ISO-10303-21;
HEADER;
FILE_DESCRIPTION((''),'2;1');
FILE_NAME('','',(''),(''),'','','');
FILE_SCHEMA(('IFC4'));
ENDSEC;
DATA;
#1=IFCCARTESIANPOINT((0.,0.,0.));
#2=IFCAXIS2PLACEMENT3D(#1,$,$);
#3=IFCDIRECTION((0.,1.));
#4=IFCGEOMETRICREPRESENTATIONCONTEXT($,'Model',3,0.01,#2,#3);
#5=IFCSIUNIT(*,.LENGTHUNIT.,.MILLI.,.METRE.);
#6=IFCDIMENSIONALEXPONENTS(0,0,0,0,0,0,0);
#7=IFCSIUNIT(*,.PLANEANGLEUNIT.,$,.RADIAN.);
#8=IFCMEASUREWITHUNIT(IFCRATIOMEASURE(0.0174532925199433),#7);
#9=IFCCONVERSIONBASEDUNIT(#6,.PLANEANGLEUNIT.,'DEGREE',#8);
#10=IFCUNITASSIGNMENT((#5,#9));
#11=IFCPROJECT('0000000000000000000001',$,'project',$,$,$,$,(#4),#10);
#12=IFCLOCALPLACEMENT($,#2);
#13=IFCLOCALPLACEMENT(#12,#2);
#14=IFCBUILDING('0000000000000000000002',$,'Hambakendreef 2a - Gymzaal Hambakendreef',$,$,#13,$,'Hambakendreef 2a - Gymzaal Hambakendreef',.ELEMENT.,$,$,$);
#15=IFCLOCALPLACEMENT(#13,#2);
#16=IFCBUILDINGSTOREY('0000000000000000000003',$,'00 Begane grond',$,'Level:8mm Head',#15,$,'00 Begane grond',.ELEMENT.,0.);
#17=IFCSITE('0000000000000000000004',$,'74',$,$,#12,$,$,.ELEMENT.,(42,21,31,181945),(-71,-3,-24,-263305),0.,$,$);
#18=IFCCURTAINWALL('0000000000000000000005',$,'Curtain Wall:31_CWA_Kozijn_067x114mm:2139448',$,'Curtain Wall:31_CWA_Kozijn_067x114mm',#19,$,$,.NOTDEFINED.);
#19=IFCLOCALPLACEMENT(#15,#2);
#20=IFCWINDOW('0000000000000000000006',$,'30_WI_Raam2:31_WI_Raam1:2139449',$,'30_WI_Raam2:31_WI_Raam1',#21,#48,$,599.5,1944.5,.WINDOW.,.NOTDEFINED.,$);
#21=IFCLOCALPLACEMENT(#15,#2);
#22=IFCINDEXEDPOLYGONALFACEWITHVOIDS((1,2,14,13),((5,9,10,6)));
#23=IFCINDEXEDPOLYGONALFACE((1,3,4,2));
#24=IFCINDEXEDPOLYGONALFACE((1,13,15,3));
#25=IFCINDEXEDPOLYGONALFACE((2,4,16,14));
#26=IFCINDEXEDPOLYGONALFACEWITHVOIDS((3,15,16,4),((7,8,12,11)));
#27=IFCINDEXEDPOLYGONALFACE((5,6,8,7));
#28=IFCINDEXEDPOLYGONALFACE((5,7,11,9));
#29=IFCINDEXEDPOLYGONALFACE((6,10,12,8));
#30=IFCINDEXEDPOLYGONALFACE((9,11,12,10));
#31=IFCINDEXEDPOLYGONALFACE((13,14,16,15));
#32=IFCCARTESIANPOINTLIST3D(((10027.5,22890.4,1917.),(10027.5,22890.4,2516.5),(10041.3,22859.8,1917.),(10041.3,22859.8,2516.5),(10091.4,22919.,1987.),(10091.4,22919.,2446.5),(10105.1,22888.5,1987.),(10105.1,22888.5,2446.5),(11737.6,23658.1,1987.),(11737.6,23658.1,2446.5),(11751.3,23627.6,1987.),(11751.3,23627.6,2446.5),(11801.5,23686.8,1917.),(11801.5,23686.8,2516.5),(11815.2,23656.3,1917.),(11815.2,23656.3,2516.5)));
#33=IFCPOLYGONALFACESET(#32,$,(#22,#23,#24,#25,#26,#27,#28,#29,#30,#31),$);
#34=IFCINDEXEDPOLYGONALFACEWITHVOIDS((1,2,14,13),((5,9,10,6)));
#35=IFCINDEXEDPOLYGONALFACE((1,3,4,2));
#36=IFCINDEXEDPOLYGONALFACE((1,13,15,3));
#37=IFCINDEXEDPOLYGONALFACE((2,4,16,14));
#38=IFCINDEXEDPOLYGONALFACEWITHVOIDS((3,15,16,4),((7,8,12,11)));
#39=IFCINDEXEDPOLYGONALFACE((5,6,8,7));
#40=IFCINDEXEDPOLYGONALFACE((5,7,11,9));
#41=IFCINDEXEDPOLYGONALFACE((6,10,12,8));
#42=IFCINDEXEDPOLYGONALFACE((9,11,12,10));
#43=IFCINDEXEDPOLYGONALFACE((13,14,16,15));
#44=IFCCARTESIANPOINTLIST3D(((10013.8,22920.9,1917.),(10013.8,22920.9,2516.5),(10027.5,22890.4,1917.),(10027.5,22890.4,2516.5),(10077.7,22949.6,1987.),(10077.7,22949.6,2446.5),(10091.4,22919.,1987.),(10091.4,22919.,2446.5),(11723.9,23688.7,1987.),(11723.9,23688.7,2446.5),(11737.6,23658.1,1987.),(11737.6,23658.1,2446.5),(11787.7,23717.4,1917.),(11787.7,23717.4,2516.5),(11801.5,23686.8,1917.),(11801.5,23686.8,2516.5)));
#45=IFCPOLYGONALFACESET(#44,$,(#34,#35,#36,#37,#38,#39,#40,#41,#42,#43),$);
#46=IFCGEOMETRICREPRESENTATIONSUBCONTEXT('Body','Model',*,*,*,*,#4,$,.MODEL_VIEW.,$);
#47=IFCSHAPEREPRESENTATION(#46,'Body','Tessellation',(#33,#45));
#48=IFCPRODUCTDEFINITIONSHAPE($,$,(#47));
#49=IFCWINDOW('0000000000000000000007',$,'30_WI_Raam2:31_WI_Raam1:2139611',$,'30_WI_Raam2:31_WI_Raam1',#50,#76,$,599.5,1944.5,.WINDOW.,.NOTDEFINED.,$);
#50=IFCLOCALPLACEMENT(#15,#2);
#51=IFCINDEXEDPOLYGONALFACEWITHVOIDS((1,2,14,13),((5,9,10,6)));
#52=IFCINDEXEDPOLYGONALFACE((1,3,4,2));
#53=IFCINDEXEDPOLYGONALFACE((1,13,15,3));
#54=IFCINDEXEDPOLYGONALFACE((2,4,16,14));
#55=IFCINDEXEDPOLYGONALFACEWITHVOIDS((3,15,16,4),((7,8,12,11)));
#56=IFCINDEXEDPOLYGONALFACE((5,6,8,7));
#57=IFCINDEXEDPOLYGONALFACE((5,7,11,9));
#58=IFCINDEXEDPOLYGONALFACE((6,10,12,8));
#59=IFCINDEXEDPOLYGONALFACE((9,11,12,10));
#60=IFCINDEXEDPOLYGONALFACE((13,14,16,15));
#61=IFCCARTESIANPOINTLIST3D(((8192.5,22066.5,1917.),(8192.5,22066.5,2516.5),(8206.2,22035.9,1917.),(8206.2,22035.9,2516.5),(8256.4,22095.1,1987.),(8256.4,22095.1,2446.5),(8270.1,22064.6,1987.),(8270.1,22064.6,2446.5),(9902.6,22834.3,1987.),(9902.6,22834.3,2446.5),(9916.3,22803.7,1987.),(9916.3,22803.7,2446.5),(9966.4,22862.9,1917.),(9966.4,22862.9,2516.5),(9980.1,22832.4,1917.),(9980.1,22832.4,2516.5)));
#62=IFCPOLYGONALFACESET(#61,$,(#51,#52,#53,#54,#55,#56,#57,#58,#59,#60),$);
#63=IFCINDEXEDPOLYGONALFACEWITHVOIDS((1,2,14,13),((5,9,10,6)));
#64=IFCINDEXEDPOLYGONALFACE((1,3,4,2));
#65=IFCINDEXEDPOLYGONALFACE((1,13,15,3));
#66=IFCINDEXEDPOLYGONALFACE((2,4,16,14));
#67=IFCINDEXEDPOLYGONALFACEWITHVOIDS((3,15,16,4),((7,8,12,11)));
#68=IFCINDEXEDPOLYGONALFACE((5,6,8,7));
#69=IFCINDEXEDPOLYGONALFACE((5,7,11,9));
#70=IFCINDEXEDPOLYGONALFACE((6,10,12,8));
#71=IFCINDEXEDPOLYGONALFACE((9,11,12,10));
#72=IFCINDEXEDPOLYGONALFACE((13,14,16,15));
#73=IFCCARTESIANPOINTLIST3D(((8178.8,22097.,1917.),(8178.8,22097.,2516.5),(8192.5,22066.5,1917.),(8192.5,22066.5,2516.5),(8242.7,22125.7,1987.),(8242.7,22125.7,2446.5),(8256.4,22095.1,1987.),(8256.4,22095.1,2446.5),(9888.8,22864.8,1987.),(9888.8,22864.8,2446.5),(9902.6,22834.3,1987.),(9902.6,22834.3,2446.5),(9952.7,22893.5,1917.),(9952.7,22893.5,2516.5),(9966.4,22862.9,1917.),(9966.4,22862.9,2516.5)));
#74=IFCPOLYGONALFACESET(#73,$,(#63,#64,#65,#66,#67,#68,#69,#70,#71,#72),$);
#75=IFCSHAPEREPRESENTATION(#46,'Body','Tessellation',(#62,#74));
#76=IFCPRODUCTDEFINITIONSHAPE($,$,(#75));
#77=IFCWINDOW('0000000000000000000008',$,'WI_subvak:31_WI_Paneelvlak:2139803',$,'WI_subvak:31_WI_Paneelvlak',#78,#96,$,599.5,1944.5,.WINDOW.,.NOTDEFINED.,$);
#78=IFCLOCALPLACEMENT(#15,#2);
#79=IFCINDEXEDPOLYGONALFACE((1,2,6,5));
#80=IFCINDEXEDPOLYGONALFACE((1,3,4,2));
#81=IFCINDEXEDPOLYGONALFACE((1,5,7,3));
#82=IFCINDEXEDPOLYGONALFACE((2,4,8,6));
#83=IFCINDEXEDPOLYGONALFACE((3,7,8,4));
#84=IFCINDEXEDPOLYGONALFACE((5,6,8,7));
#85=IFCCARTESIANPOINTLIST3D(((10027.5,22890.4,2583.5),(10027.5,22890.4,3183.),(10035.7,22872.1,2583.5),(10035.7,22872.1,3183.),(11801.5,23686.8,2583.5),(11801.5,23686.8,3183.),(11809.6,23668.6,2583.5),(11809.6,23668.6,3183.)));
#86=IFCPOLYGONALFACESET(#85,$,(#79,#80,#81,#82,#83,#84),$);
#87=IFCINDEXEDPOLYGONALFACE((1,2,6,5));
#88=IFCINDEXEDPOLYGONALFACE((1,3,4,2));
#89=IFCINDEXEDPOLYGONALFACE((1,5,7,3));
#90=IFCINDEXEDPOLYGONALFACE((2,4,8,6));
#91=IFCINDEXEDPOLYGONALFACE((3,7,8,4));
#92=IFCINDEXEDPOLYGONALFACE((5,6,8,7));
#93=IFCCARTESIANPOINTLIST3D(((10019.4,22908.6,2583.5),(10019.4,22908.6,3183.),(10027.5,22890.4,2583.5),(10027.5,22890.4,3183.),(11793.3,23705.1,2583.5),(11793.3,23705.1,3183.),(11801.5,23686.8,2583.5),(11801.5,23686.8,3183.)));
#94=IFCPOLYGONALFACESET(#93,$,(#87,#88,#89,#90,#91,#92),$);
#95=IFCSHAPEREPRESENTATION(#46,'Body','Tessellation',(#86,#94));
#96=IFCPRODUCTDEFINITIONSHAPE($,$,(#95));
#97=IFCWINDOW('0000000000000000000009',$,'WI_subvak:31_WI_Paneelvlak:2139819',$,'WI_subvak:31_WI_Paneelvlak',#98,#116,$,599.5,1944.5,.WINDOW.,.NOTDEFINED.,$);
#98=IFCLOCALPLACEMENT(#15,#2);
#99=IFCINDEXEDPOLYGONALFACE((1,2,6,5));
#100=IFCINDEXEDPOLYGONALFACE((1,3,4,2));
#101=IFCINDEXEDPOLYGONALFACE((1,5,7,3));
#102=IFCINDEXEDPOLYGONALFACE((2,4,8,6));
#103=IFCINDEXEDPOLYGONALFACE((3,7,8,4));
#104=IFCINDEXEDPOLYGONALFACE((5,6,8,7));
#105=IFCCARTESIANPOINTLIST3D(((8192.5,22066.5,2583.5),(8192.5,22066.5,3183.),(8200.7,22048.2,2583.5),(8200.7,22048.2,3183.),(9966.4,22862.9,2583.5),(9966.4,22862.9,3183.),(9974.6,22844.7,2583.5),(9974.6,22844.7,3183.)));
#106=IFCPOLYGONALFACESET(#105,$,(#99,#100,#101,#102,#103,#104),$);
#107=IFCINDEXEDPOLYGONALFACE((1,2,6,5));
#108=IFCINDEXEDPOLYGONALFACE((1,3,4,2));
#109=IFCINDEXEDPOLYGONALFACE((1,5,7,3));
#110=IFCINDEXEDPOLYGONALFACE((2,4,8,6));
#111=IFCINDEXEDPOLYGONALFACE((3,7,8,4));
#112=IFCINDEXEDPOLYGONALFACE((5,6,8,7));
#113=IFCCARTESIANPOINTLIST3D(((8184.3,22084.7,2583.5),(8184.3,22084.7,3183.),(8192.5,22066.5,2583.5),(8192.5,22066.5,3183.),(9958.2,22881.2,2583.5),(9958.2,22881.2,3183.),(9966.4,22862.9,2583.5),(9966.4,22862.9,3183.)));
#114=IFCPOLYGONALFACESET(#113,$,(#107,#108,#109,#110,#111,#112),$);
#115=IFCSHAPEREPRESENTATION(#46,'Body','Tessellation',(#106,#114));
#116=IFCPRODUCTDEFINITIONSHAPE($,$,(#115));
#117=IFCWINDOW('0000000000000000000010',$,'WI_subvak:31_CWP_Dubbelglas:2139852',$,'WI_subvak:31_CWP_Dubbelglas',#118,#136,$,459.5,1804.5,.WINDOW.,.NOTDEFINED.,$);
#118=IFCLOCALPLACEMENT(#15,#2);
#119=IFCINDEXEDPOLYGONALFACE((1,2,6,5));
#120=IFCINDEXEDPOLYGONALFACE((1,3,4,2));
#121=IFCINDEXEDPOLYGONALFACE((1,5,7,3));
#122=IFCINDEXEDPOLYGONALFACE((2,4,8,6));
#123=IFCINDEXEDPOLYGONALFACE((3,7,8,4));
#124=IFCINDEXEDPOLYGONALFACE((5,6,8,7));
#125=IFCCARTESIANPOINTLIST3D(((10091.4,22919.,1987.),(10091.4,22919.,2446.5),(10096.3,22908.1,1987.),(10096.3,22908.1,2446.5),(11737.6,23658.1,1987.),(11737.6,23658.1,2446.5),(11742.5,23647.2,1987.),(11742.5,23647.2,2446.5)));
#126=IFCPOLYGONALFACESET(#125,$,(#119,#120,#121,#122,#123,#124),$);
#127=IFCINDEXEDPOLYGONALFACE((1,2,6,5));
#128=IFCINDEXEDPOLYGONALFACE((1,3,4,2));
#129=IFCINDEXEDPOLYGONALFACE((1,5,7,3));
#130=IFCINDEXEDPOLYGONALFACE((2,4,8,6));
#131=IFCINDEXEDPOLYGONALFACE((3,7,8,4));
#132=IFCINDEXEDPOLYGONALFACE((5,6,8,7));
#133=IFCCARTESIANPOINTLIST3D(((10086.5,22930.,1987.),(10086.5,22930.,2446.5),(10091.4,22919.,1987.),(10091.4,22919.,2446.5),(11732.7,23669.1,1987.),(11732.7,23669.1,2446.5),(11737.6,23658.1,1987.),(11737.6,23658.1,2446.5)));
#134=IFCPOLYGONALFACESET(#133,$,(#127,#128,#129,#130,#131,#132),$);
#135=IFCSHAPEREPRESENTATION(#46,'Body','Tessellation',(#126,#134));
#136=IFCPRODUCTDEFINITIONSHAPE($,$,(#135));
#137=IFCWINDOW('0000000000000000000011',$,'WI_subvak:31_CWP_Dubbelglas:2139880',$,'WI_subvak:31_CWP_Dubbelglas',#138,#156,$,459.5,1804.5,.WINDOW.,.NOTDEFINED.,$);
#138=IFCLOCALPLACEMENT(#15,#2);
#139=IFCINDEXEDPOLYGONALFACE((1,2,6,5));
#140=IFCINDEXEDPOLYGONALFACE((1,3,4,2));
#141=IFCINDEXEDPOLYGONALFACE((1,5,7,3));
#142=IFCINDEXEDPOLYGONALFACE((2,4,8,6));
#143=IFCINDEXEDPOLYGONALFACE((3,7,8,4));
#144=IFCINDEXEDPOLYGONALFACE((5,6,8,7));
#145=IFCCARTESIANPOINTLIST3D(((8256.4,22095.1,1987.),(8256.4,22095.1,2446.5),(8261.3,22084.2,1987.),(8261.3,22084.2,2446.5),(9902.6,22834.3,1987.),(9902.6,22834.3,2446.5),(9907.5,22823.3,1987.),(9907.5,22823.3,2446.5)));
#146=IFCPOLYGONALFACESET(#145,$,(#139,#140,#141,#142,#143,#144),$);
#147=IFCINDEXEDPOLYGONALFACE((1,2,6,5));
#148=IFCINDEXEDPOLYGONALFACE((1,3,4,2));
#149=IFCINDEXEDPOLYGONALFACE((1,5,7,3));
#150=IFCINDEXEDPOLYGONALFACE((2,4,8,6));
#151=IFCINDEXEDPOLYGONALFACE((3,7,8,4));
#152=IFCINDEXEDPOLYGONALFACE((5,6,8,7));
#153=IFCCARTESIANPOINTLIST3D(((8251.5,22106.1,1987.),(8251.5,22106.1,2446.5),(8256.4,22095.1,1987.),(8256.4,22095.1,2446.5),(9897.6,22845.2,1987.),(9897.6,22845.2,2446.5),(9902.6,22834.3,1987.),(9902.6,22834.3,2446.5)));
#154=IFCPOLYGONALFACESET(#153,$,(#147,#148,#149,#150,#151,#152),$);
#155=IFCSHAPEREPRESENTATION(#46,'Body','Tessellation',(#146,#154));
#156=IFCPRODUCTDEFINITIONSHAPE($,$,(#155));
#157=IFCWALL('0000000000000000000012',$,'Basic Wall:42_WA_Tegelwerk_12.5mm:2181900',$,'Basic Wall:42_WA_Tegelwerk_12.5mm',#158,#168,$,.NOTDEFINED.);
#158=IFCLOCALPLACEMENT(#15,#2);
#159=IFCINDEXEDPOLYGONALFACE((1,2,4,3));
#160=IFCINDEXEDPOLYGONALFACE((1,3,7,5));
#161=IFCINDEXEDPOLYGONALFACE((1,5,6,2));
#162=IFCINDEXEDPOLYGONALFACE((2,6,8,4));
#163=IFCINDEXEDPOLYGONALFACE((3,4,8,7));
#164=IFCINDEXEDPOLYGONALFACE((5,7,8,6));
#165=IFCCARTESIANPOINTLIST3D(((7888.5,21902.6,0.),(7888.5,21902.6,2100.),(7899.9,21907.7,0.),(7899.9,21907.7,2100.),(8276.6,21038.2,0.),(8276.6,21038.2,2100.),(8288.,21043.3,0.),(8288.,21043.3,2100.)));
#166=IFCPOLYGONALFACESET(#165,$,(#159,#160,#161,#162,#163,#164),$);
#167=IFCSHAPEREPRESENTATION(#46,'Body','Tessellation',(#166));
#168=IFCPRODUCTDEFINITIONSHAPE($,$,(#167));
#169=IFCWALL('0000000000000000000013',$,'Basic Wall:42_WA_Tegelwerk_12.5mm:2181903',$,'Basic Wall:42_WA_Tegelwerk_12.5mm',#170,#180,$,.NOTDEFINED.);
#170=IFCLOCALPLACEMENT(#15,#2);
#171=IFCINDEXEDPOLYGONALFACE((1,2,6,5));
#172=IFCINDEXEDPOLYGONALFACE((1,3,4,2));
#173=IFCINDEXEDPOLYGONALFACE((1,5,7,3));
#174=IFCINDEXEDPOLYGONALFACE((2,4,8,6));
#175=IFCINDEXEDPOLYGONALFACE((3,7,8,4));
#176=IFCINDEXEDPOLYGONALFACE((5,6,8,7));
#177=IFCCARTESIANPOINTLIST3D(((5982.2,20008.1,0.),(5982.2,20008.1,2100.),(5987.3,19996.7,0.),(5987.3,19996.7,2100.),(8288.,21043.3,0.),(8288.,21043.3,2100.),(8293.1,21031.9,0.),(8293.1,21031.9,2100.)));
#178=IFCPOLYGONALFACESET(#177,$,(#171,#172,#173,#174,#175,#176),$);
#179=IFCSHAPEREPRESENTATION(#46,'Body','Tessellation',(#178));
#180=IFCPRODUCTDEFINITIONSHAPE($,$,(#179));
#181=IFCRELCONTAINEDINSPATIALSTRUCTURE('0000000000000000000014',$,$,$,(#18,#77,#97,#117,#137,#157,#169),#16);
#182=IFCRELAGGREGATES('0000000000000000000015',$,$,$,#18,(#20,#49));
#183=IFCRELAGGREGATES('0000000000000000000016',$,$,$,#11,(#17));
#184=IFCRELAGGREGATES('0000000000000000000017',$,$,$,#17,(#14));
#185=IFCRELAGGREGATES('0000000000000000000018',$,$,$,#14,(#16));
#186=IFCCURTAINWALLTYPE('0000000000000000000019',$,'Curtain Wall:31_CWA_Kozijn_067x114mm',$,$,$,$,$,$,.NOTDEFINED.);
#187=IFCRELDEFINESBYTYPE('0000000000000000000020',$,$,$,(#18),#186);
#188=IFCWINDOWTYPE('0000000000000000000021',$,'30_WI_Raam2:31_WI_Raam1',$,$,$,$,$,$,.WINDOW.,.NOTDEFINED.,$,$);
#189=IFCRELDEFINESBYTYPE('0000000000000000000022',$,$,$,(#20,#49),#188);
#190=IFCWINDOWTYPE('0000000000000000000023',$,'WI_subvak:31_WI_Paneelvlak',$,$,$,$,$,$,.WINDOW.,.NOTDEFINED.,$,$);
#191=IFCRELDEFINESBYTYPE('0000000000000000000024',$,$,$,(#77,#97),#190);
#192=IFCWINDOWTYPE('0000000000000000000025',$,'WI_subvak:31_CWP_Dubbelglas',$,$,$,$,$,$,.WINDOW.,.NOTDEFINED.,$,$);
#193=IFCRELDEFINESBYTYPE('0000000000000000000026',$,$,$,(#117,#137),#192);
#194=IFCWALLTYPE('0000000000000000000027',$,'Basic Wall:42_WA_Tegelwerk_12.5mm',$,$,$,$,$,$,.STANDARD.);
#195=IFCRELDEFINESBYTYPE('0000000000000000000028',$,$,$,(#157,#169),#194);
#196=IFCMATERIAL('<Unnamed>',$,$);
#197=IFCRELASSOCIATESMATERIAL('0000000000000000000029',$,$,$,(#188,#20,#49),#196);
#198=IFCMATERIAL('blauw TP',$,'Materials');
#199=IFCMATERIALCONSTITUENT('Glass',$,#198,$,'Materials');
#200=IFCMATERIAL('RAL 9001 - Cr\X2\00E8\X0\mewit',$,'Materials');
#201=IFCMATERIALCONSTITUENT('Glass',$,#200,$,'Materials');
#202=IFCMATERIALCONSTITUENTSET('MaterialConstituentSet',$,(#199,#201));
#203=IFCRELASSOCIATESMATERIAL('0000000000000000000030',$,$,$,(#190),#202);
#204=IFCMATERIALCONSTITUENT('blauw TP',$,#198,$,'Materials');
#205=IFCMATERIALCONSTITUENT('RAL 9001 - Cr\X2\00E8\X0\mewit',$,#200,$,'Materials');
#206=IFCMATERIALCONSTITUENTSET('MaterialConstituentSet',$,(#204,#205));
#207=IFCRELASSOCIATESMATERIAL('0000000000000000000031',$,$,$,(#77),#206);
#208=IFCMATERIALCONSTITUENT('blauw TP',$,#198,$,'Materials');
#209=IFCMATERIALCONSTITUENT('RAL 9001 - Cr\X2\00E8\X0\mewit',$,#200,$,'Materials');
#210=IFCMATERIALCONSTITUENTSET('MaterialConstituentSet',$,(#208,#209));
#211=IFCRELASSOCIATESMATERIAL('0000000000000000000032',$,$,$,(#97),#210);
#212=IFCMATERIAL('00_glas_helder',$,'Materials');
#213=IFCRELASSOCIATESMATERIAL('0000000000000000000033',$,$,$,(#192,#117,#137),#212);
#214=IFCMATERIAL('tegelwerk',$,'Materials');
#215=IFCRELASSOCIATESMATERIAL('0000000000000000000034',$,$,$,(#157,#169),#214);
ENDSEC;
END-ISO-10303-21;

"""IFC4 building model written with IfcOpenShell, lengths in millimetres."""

from ifc_helpers import new_model, entity, si_unit, converted_unit, direction, frame, origin, place, context, subcontext, project, spatial, indexed_curve, outline, extrude, source, transform, mapped, material, constituent, constituent_set, type_object, type_shapes, element, aggregate, save


model = new_model("IFC4")

# Units and contexts
model_context = context("Model", 3, precision=0.01, world=origin(), true_north=direction((0.0, 1.0)))
body_context = subcontext(model_context, "Body", "Model", "MODEL_VIEW")
ifc_project = project(units=[si_unit("LENGTHUNIT", "METRE", prefix="MILLI"), converted_unit("PLANEANGLEUNIT", "DEGREE", entity("IfcRatioMeasure", 0.0174532925199433), si_unit("PLANEANGLEUNIT", "RADIAN"), dimensions=[0, 0, 0, 0, 0, 0, 0])], contexts=[model_context])

# Site, building, storey
site_placement = place(None, origin())
site = spatial("IfcSite", under=ifc_project, at=site_placement, Name="74", CompositionType="ELEMENT", RefLatitude=(42, 21, 31, 181945), RefLongitude=(-71, -3, -24, -263305), RefElevation=0.0)
building_placement = place(site_placement, origin())
building = spatial("IfcBuilding", under=site, at=building_placement, Name="Hambakendreef 2a - Gymzaal Hambakendreef", LongName="Hambakendreef 2a - Gymzaal Hambakendreef", CompositionType="ELEMENT")
storey_placement = place(building_placement, origin())
storey = spatial("IfcBuildingStorey", under=building, at=storey_placement, Name="00 Begane grond", ObjectType="Level:8mm Head", LongName="00 Begane grond", CompositionType="ELEMENT", Elevation=0.0)

# Curtain wall
curtain_wall_type_1 = type_object("IfcCurtainWallType", Name="Curtain Wall:31_CWA_Kozijn_067x114mm", PredefinedType="NOTDEFINED")
curtain_wall_1_placement = place(storey_placement, origin())
curtain_wall_1 = element("IfcCurtainWall", 1, at=curtain_wall_1_placement, inside=storey, type_object=curtain_wall_type_1, Name="Curtain Wall:31_CWA_Kozijn_067x114mm:2139448", ObjectType="Curtain Wall:31_CWA_Kozijn_067x114mm", PredefinedType="NOTDEFINED")

# Shared definitions
ifc_material_1 = material(Name="<Unnamed>")

# Windows
window_type_1 = type_object("IfcWindowType", Name="30_WI_Raam2:31_WI_Raam1", PartitioningType="NOTDEFINED", PredefinedType="WINDOW", material=ifc_material_1)
shared_shape_1 = source(origin(), body_context, "Body", "SweptSolid", [
    extrude(outline(indexed_curve([(-972.2, -299.7), (972.2, -299.7), (972.2, 299.7), (-972.2, 299.7), (-972.2, -299.7)], self_intersect=False), holes=[indexed_curve([(-902.2, 229.7), (902.2, 229.7), (902.2, -229.8), (-902.2, -229.8), (-902.2, 229.7)], self_intersect=False)]), frame((0.0, 0.0, 299.8), z_axis=(0.0, 1.0, 0.0), x_axis=(1.0, 0.0, 0.0)), (0.0, 0.0, 1.0), 33.5),
    extrude(outline(indexed_curve([(-972.2, -299.7), (972.2, -299.7), (972.2, 299.7), (-972.2, 299.7), (-972.2, -299.7)], self_intersect=False), holes=[indexed_curve([(-902.2, 229.7), (902.2, 229.7), (902.2, -229.8), (-902.2, -229.8), (-902.2, 229.7)], self_intersect=False)]), frame((0.0, -33.5, 299.8), z_axis=(0.0, 1.0, 0.0), x_axis=(1.0, 0.0, 0.0)), (0.0, 0.0, 1.0), 33.5),
])
type_shapes(window_type_1, [shared_shape_1])
window_1_placement = place(curtain_wall_1_placement, frame((10914.5, 23288.6, 1917.0), z_axis=(0.0, 0.0, 1.0), x_axis=(-0.91227, -0.40959, 0.0)))
window_1 = element("IfcWindow", 2, at=window_1_placement, type_object=window_type_1, material=ifc_material_1, Name="30_WI_Raam2:31_WI_Raam1:2139449", ObjectType="30_WI_Raam2:31_WI_Raam1", OverallHeight=599.5, OverallWidth=1944.5, PartitioningType="NOTDEFINED", PredefinedType="WINDOW", context=body_context, shape_type="MappedRepresentation", body=[
    mapped(shared_shape_1, transform((0.0, 0.0, 0.0), scale=1.0)),
])
window_2_placement = place(curtain_wall_1_placement, frame((9079.5, 22464.7, 1917.0), z_axis=(0.0, 0.0, 1.0), x_axis=(-0.91227, -0.40959, 0.0)))
window_2 = element("IfcWindow", 3, at=window_2_placement, type_object=window_type_1, material=ifc_material_1, Name="30_WI_Raam2:31_WI_Raam1:2139611", ObjectType="30_WI_Raam2:31_WI_Raam1", OverallHeight=599.5, OverallWidth=1944.5, PartitioningType="NOTDEFINED", PredefinedType="WINDOW", context=body_context, shape_type="MappedRepresentation", body=[
    mapped(shared_shape_1, transform((0.0, 0.0, 0.0), scale=1.0)),
])
aggregate(curtain_wall_1, [window_1, window_2])

# Windows
ifc_material_2 = material(Name="blauw TP", Category="Materials")
ifc_constituent_1 = constituent(ifc_material_2, Name="blauw TP", Category="Materials")
ifc_material_3 = material(Name="RAL 9001 - Crèmewit", Category="Materials")
ifc_constituent_2 = constituent(ifc_material_3, Name="RAL 9001 - Crèmewit", Category="Materials")
ifc_constituent_set_1 = constituent_set(constituents=[ifc_constituent_1, ifc_constituent_2], Name="MaterialConstituentSet")
ifc_constituent_3 = constituent(ifc_material_2, Name="Glass", Category="Materials")
ifc_constituent_4 = constituent(ifc_material_3, Name="Glass", Category="Materials")
ifc_constituent_set_2 = constituent_set(constituents=[ifc_constituent_3, ifc_constituent_4], Name="MaterialConstituentSet")
window_type_2 = type_object("IfcWindowType", Name="WI_subvak:31_WI_Paneelvlak", PartitioningType="NOTDEFINED", PredefinedType="WINDOW", material=ifc_constituent_set_2)
shared_shape_2 = source(origin(), body_context, "Body", "SweptSolid", [
    extrude(outline(indexed_curve([(-10.0, -972.2), (10.0, -972.2), (10.0, 972.2), (-10.0, 972.2), (-10.0, -972.2)], self_intersect=False)), frame((0.0, 10.0, 0.0), z_axis=(0.0, 0.0, 1.0), x_axis=(0.0, -1.0, 0.0)), (0.0, 0.0, 1.0), 599.5),
    extrude(outline(indexed_curve([(-10.0, -972.2), (10.0, -972.2), (10.0, 972.2), (-10.0, 972.2), (-10.0, -972.2)], self_intersect=False)), frame((0.0, -10.0, 0.0), z_axis=(0.0, 0.0, 1.0), x_axis=(0.0, -1.0, 0.0)), (0.0, 0.0, 1.0), 599.5),
])
type_shapes(window_type_2, [shared_shape_2])
window_3_placement = place(storey_placement, frame((10914.5, 23288.6, 2583.5), z_axis=(0.0, 0.0, 1.0), x_axis=(-0.91227, -0.40959, 0.0)))
element("IfcWindow", 4, at=window_3_placement, inside=storey, type_object=window_type_2, material=ifc_constituent_set_1, Name="WI_subvak:31_WI_Paneelvlak:2139803", ObjectType="WI_subvak:31_WI_Paneelvlak", OverallHeight=599.5, OverallWidth=1944.5, PartitioningType="NOTDEFINED", PredefinedType="WINDOW", context=body_context, shape_type="MappedRepresentation", body=[
    mapped(shared_shape_2, transform((0.0, 0.0, 0.0), scale=1.0)),
])
ifc_constituent_5 = constituent(ifc_material_2, Name="blauw TP", Category="Materials")
ifc_constituent_6 = constituent(ifc_material_3, Name="RAL 9001 - Crèmewit", Category="Materials")
ifc_constituent_set_3 = constituent_set(constituents=[ifc_constituent_5, ifc_constituent_6], Name="MaterialConstituentSet")
window_4_placement = place(storey_placement, frame((9079.5, 22464.7, 2583.5), z_axis=(0.0, 0.0, 1.0), x_axis=(-0.91227, -0.40959, 0.0)))
element("IfcWindow", 5, at=window_4_placement, inside=storey, type_object=window_type_2, material=ifc_constituent_set_3, Name="WI_subvak:31_WI_Paneelvlak:2139819", ObjectType="WI_subvak:31_WI_Paneelvlak", OverallHeight=599.5, OverallWidth=1944.5, PartitioningType="NOTDEFINED", PredefinedType="WINDOW", context=body_context, shape_type="MappedRepresentation", body=[
    mapped(shared_shape_2, transform((0.0, 0.0, 0.0), scale=1.0)),
])
ifc_material_4 = material(Name="00_glas_helder", Category="Materials")
window_type_3 = type_object("IfcWindowType", Name="WI_subvak:31_CWP_Dubbelglas", PartitioningType="NOTDEFINED", PredefinedType="WINDOW", material=ifc_material_4)
shared_shape_3 = source(origin(), body_context, "Body", "SweptSolid", [
    extrude(outline(indexed_curve([(-6.0, -902.2), (6.0, -902.2), (6.0, 902.2), (-6.0, 902.2), (-6.0, -902.2)], self_intersect=False)), frame((0.0, 6.0, 0.0), z_axis=(0.0, 0.0, 1.0), x_axis=(0.0, -1.0, 0.0)), (0.0, 0.0, 1.0), 459.5),
    extrude(outline(indexed_curve([(-6.0, -902.2), (6.0, -902.2), (6.0, 902.2), (-6.0, 902.2), (-6.0, -902.2)], self_intersect=False)), frame((0.0, -6.0, 0.0), z_axis=(0.0, 0.0, 1.0), x_axis=(0.0, -1.0, 0.0)), (0.0, 0.0, 1.0), 459.5),
])
type_shapes(window_type_3, [shared_shape_3])
for number, where, z_axis, x_axis, name in (
    (6, (10914.5, 23288.6, 1987.0), (0.0, 0.0, 1.0), (-0.91227, -0.40959, 0.0), "WI_subvak:31_CWP_Dubbelglas:2139852"),
    (7, (9079.5, 22464.7, 1987.0), (0.0, 0.0, 1.0), (-0.91227, -0.40959, 0.0), "WI_subvak:31_CWP_Dubbelglas:2139880"),
):
    element("IfcWindow", number, at=place(storey_placement, frame(where, z_axis=z_axis, x_axis=x_axis)), inside=storey, type_object=window_type_3, material=ifc_material_4, Name=name, ObjectType="WI_subvak:31_CWP_Dubbelglas", OverallHeight=459.5, OverallWidth=1804.5, PartitioningType="NOTDEFINED", PredefinedType="WINDOW", context=body_context, shape_type="MappedRepresentation", body=[
        mapped(shared_shape_3, transform((0.0, 0.0, 0.0), scale=1.0)),
    ])

# Walls
ifc_material_5 = material(Name="tegelwerk", Category="Materials")
wall_type_1 = type_object("IfcWallType", Name="Basic Wall:42_WA_Tegelwerk_12.5mm", PredefinedType="STANDARD")
wall_1_placement = place(storey_placement, frame((7894.2, 21905.1, 0.0), z_axis=(0.0, 0.0, 1.0), x_axis=(0.40959, -0.91227, 0.0)))
element("IfcWall", 8, at=wall_1_placement, inside=storey, type_object=wall_type_1, material=ifc_material_5, Name="Basic Wall:42_WA_Tegelwerk_12.5mm:2181900", ObjectType="Basic Wall:42_WA_Tegelwerk_12.5mm", PredefinedType="NOTDEFINED", context=body_context, shape_type="SweptSolid", body=[
    extrude(outline(indexed_curve([(947.5, 6.2), (0.0, 6.2), (0.0, -6.2), (947.5, -6.2), (947.5, 6.2)], self_intersect=False)), origin(), (0.0, 0.0, 1.0), 2100.0),
])
wall_2_placement = place(storey_placement, frame((8290.5, 21037.6, 0.0), z_axis=(0.0, 0.0, 1.0), x_axis=(-0.91227, -0.40959, 0.0)))
element("IfcWall", 9, at=wall_2_placement, inside=storey, type_object=wall_type_1, material=ifc_material_5, Name="Basic Wall:42_WA_Tegelwerk_12.5mm:2181903", ObjectType="Basic Wall:42_WA_Tegelwerk_12.5mm", PredefinedType="NOTDEFINED", context=body_context, shape_type="SweptSolid", body=[
    extrude(outline(indexed_curve([(2527.5, 6.3), (0.0, 6.3), (0.0, -6.3), (2527.5, -6.2), (2527.5, 6.3)], self_intersect=False)), origin(), (0.0, 0.0, 1.0), 2100.0),
])

save(model, "model.ifc")
